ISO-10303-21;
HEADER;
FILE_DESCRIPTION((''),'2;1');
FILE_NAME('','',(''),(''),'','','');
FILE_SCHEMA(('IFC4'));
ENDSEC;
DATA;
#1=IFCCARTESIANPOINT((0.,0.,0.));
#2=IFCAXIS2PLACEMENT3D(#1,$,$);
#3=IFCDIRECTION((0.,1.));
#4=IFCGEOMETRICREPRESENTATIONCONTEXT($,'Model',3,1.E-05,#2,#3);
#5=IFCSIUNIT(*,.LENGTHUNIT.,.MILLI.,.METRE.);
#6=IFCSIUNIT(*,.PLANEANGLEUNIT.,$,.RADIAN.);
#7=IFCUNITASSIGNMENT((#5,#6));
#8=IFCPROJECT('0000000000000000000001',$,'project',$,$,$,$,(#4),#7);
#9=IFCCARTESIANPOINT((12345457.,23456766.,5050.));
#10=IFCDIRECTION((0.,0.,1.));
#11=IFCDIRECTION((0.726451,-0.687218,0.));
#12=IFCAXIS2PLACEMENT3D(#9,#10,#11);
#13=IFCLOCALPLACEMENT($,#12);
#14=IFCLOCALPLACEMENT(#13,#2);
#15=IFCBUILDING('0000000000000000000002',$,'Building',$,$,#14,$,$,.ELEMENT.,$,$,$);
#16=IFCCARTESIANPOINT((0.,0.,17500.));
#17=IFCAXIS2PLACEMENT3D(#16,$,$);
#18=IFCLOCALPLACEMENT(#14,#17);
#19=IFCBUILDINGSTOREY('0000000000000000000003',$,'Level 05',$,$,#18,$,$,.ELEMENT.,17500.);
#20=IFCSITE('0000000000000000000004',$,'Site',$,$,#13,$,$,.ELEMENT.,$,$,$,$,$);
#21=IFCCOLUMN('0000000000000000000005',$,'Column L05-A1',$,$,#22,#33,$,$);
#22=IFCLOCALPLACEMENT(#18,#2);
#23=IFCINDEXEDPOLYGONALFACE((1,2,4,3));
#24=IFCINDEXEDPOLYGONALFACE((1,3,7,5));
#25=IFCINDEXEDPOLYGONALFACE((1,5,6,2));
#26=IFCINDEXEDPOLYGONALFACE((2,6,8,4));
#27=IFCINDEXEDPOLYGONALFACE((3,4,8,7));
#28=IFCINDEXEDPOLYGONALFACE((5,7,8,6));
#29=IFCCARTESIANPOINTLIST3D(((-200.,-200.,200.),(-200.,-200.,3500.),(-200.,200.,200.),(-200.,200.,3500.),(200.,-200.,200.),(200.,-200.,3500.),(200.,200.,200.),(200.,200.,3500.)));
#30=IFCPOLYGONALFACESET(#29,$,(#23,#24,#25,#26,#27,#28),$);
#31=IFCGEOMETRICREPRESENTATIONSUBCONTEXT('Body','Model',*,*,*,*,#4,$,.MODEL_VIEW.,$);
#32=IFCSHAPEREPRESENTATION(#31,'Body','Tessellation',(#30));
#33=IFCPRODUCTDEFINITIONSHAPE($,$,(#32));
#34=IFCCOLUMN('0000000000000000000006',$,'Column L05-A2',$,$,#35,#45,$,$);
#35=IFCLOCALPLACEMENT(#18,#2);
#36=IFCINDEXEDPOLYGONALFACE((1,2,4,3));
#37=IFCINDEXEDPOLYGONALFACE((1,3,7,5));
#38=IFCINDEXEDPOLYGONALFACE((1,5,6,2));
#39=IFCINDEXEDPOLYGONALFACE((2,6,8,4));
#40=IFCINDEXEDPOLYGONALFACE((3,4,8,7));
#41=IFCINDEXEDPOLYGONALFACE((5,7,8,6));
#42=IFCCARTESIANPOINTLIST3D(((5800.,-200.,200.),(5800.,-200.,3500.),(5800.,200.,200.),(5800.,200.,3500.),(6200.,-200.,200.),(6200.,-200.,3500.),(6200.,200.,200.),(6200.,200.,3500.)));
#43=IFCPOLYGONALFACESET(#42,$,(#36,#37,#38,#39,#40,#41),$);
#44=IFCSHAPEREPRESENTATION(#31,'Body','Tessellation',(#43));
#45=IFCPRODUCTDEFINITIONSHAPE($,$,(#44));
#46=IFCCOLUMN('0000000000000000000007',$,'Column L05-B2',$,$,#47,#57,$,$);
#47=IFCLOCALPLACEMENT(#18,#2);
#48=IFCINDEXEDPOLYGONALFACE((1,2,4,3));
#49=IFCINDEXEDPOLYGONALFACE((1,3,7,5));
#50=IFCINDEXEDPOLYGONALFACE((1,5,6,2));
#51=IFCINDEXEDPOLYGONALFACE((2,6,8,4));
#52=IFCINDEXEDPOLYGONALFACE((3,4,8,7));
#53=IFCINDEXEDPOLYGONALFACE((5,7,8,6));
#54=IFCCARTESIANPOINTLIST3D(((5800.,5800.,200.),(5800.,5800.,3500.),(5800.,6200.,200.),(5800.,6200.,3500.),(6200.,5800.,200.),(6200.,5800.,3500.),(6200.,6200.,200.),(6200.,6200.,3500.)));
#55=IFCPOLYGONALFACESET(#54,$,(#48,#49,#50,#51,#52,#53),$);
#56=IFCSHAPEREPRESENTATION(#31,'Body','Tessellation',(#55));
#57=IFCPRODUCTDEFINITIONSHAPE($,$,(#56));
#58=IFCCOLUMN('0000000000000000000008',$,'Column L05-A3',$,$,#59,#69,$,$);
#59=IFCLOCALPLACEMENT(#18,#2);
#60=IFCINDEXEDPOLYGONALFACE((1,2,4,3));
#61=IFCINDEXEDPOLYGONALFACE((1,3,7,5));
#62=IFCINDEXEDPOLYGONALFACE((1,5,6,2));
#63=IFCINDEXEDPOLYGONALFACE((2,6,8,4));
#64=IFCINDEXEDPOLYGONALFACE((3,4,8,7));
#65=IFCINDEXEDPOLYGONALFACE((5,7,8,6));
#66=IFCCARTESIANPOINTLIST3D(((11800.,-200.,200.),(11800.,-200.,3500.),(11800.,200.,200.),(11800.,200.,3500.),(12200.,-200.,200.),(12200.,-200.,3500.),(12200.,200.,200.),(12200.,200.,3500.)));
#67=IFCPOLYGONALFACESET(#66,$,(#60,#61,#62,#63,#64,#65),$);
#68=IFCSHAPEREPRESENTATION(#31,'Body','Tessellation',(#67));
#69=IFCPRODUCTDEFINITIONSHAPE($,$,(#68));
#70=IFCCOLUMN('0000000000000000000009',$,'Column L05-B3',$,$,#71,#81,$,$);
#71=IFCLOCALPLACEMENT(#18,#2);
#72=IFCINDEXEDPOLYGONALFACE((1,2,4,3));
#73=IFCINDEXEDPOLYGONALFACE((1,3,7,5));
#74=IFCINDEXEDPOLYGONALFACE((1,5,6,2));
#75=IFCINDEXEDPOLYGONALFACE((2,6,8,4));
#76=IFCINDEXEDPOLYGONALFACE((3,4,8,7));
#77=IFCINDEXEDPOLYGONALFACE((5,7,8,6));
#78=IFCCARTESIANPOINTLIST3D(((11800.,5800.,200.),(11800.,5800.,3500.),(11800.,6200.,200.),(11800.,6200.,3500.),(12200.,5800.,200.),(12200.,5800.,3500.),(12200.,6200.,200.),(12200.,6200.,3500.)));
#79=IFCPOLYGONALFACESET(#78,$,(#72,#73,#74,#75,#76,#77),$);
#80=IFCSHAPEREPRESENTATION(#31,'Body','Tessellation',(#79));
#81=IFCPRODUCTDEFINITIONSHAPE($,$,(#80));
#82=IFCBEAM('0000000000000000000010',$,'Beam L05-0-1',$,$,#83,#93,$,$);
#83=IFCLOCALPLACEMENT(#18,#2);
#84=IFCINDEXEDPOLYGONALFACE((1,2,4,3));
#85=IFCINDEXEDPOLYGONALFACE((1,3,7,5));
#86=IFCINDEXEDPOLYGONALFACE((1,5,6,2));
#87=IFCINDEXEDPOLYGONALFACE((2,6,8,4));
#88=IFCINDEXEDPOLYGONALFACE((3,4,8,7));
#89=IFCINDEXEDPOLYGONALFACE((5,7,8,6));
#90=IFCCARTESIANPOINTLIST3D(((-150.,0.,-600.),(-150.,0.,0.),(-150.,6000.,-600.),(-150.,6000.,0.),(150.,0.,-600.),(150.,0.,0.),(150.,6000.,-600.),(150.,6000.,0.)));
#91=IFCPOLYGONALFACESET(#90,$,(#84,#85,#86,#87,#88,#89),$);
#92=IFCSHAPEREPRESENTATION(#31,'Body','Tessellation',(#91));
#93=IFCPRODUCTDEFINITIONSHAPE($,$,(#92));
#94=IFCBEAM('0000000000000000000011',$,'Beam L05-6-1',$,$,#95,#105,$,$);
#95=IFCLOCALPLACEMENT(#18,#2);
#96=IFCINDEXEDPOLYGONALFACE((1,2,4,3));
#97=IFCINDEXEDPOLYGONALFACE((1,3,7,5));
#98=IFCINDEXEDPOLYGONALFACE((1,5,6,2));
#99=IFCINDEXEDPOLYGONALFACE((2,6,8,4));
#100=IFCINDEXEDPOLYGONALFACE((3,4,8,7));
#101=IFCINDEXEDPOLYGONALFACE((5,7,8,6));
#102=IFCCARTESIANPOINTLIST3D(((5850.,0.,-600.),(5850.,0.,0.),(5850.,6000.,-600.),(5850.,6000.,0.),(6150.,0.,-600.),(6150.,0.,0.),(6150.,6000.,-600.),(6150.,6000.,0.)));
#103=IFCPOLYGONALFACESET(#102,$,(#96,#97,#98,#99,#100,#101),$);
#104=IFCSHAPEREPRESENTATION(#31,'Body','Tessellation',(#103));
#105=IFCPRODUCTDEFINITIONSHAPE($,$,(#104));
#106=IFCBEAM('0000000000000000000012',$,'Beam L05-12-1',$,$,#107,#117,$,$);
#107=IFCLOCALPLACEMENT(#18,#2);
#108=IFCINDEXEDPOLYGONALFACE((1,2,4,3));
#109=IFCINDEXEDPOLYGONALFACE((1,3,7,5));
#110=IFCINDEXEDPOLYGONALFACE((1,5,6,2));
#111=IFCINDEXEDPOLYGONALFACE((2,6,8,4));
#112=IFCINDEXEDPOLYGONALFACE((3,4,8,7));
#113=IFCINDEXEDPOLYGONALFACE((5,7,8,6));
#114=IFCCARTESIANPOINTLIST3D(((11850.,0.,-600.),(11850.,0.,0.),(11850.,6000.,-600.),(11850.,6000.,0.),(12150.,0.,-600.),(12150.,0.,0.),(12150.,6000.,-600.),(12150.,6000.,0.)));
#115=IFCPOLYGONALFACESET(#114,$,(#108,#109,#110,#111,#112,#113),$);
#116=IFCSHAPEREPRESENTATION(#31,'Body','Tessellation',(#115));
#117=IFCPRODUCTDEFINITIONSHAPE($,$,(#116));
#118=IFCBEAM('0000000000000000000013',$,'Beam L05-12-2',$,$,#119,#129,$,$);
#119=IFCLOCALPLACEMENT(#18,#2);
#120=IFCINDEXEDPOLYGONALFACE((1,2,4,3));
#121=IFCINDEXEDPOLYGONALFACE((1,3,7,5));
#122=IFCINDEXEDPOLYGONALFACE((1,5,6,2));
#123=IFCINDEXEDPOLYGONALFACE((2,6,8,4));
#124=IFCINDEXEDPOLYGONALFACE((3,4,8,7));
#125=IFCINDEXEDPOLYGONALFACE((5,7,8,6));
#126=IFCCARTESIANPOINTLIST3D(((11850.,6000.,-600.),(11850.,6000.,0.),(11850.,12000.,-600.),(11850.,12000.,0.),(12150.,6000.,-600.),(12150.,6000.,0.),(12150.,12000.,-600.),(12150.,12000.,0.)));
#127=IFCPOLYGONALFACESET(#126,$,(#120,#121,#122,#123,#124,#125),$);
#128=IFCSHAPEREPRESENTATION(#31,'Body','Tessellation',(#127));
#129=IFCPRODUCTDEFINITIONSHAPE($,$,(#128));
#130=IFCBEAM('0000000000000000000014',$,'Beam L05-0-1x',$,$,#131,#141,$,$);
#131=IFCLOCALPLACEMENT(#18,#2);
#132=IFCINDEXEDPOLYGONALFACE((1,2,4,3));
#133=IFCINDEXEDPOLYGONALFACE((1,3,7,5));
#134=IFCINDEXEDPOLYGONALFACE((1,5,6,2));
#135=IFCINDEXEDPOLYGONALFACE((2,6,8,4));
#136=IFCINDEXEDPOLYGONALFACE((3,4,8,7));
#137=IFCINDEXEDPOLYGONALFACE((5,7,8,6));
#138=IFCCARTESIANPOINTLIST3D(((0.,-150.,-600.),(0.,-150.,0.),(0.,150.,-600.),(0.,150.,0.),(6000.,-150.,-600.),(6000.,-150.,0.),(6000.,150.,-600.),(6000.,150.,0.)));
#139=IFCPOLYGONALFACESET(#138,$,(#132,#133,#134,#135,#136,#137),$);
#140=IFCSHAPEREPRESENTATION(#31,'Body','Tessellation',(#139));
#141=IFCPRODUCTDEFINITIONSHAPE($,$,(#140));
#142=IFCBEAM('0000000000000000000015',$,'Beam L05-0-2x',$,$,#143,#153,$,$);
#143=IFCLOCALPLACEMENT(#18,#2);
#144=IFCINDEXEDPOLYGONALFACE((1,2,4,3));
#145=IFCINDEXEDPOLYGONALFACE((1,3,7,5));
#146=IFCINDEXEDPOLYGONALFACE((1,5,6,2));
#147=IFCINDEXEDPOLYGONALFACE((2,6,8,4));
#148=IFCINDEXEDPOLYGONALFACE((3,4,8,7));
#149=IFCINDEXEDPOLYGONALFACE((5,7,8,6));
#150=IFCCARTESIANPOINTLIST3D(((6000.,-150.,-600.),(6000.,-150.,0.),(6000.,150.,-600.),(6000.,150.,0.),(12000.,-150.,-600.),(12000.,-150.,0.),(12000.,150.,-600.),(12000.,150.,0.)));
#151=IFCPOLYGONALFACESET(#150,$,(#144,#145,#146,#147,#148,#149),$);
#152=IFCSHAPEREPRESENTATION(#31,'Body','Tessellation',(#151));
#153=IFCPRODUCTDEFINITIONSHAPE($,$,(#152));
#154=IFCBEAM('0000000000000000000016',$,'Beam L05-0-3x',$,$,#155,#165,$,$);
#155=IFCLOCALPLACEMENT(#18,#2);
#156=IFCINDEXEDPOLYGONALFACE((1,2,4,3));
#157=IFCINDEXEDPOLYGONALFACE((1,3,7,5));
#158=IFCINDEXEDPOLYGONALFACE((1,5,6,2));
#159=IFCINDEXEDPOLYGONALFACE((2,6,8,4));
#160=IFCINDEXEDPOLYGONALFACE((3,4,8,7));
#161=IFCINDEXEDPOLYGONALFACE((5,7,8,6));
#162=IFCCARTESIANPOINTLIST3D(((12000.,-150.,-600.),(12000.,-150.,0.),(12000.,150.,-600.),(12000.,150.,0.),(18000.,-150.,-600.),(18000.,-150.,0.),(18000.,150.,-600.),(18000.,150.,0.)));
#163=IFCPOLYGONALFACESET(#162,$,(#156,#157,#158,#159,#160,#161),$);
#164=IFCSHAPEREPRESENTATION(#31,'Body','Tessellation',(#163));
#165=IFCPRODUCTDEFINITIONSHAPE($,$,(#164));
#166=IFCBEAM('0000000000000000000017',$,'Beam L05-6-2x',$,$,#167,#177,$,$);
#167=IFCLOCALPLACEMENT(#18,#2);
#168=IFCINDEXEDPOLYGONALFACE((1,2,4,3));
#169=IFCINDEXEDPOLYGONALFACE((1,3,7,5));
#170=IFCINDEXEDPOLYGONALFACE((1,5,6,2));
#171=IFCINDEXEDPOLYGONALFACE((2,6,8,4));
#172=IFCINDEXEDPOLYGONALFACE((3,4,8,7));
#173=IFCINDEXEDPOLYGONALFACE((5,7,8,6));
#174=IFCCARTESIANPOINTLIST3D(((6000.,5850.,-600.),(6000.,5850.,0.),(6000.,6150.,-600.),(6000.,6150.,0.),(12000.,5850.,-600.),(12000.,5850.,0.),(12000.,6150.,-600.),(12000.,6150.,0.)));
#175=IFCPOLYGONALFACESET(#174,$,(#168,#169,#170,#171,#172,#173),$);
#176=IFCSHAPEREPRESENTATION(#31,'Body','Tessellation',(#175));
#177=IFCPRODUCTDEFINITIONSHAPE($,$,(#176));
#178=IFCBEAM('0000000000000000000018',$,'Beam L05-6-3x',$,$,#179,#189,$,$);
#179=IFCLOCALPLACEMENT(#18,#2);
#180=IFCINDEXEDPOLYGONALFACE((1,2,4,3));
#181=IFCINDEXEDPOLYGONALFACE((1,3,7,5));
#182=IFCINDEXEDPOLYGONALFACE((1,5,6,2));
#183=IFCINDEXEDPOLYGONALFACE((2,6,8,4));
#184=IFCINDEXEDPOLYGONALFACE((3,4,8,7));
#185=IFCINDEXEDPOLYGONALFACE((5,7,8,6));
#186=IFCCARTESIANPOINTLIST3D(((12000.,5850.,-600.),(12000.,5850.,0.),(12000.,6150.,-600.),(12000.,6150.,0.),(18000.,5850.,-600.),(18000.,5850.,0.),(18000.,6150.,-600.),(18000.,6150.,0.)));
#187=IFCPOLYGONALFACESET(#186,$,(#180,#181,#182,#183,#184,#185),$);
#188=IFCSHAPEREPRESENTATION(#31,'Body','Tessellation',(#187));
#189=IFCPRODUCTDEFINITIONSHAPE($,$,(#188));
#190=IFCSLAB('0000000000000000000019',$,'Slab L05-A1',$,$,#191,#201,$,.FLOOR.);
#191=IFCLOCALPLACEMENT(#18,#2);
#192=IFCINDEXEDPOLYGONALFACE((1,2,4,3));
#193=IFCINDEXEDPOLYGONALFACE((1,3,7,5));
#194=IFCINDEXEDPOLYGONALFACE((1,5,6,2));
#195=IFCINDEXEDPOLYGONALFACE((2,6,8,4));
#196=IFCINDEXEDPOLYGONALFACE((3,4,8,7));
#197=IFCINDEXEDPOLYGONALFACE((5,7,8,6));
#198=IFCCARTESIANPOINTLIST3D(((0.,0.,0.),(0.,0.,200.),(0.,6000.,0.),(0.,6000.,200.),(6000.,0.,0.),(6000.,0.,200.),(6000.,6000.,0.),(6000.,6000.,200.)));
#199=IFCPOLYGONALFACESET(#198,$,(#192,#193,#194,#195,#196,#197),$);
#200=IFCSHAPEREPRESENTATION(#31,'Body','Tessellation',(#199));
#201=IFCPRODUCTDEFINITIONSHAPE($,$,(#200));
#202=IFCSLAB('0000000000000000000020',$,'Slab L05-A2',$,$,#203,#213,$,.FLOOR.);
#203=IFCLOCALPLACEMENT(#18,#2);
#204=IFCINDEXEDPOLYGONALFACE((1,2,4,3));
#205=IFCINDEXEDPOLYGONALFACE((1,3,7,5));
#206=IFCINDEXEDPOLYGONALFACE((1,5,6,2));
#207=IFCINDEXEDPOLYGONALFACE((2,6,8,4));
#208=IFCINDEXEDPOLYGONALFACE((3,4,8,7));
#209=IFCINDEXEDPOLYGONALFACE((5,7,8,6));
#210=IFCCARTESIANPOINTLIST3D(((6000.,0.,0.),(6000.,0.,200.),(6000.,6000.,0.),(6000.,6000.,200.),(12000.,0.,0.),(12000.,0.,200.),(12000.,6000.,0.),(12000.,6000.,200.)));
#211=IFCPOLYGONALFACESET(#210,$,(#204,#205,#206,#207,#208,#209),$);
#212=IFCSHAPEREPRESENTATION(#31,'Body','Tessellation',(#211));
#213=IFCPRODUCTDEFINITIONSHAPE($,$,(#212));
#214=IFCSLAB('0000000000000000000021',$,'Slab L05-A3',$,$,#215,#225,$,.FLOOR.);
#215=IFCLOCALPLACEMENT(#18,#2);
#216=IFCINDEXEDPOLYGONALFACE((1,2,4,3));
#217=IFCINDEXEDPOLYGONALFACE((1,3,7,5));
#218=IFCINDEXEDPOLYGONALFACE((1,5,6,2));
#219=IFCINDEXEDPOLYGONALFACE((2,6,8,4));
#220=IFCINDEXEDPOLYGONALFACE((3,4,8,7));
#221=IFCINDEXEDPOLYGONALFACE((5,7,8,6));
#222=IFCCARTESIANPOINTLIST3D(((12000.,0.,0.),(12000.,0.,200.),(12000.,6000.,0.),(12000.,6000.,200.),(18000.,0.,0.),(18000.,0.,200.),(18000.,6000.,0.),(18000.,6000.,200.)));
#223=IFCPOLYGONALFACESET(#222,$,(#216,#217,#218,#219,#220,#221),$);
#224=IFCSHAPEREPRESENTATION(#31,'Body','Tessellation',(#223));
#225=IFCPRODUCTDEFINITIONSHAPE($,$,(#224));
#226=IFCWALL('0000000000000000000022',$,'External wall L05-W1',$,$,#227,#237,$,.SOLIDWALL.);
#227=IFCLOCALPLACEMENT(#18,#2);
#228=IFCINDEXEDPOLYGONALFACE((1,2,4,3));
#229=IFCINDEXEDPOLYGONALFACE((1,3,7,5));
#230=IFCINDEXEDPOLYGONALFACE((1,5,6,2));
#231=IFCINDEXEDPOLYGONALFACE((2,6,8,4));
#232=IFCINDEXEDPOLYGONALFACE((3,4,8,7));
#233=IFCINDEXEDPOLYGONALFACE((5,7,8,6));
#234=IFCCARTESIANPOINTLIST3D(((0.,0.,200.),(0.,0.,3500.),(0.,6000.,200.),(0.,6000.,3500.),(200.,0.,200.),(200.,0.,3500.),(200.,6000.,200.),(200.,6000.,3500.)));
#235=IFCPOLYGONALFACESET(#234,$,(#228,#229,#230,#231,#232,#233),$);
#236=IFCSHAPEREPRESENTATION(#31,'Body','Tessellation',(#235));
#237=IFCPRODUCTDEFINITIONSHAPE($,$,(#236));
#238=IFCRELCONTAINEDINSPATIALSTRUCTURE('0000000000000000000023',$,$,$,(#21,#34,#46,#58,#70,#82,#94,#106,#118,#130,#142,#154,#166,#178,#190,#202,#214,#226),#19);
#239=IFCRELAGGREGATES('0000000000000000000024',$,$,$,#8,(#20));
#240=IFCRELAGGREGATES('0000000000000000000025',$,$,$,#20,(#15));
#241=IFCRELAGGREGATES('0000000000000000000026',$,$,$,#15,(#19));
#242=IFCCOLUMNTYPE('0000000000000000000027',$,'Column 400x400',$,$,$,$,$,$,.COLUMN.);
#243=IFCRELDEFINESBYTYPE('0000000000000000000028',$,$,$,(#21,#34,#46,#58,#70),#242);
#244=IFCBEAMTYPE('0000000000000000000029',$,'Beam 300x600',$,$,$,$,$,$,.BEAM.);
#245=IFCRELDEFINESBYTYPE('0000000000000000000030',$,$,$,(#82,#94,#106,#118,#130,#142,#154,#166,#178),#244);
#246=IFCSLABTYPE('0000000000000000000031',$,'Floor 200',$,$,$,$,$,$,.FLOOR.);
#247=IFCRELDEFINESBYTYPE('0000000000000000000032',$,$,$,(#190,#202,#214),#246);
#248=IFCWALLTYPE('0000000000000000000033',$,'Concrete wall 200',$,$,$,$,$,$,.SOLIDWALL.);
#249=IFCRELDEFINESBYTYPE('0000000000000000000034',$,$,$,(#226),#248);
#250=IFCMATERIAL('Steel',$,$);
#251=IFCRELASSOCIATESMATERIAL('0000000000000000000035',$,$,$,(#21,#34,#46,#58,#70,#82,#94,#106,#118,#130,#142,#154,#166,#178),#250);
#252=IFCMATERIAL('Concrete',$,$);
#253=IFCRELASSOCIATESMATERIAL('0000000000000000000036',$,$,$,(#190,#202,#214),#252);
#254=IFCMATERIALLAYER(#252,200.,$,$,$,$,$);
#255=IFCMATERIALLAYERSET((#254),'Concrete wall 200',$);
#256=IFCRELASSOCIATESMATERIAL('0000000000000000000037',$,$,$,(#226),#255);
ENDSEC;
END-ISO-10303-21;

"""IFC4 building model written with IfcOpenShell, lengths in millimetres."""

from ifc_helpers import new_model, si_unit, direction, frame, origin, place, context, subcontext, project, spatial, rectangle, extrude, material, layer, layer_set, layer_usage, type_object, element, save


model = new_model("IFC4")

# Units and contexts
model_context = context("Model", 3, precision=1e-05, world=origin(), true_north=direction((0.0, 1.0)))
body_context = subcontext(model_context, "Body", "Model", "MODEL_VIEW")
ifc_project = project(units=[si_unit("LENGTHUNIT", "METRE", prefix="MILLI"), si_unit("PLANEANGLEUNIT", "RADIAN")], contexts=[model_context])

# Site, building, storey
site_placement = place(None, frame((12345457.0, 23456766.0, 5050.0), z_axis=(0.0, 0.0, 1.0), x_axis=(0.726451, -0.687218, 0.0)))
site = spatial("IfcSite", under=ifc_project, at=site_placement, Name="Site", CompositionType="ELEMENT")
building_placement = place(site_placement, origin())
building = spatial("IfcBuilding", under=site, at=building_placement, Name="Building", CompositionType="ELEMENT")
storey_placement = place(building_placement, frame((0.0, 0.0, 17500.0)))
storey = spatial("IfcBuildingStorey", under=building, at=storey_placement, Name="Level 05", CompositionType="ELEMENT", Elevation=17500.0)

# Columns
ifc_material_1 = material(Name="Steel")
column_type = type_object("IfcColumnType", Name="Column 400x400", PredefinedType="COLUMN")
for number, where, name in (
    (1, (-200.0, -200.0, 200.0), "Column L05-A1"),
    (2, (5800.0, -200.0, 200.0), "Column L05-A2"),
    (3, (5800.0, 5800.0, 200.0), "Column L05-B2"),
    (4, (11800.0, -200.0, 200.0), "Column L05-A3"),
    (5, (11800.0, 5800.0, 200.0), "Column L05-B3"),
):
    element("IfcColumn", number, at=place(storey_placement, frame(where)), inside=storey, type_object=column_type, material=ifc_material_1, Name=name, context=body_context, shape_type="SweptSolid", body=[
        extrude(rectangle(XDim=400.0, YDim=400.0), frame((200.0, 200.0, 0.0)), (0.0, 0.0, 1.0), 3300.0),
    ])

# Beams
beam_type = type_object("IfcBeamType", Name="Beam 300x600", PredefinedType="BEAM")
for number, where, name in (
    (6, (-150.0, 0.0, -600.0), "Beam L05-0-1"),
    (7, (5850.0, 0.0, -600.0), "Beam L05-6-1"),
    (8, (11850.0, 0.0, -600.0), "Beam L05-12-1"),
    (9, (11850.0, 6000.0, -600.0), "Beam L05-12-2"),
):
    element("IfcBeam", number, at=place(storey_placement, frame(where)), inside=storey, type_object=beam_type, material=ifc_material_1, Name=name, context=body_context, shape_type="SweptSolid", body=[
        extrude(rectangle(XDim=300.0, YDim=6000.0), frame((150.0, 3000.0, 0.0)), (0.0, 0.0, 1.0), 600.0),
    ])
for number, where, name in (
    (10, (0.0, -150.0, -600.0), "Beam L05-0-1x"),
    (11, (6000.0, -150.0, -600.0), "Beam L05-0-2x"),
    (12, (12000.0, -150.0, -600.0), "Beam L05-0-3x"),
    (13, (6000.0, 5850.0, -600.0), "Beam L05-6-2x"),
    (14, (12000.0, 5850.0, -600.0), "Beam L05-6-3x"),
):
    element("IfcBeam", number, at=place(storey_placement, frame(where)), inside=storey, type_object=beam_type, material=ifc_material_1, Name=name, context=body_context, shape_type="SweptSolid", body=[
        extrude(rectangle(XDim=6000.0, YDim=300.0), frame((3000.0, 150.0, 0.0)), (0.0, 0.0, 1.0), 600.0),
    ])

# Slabs
ifc_material_2 = material(Name="Concrete")
slab_type = type_object("IfcSlabType", Name="Floor 200", PredefinedType="FLOOR")
for number, where, name in (
    (15, (0.0, 0.0, 0.0), "Slab L05-A1"),
    (16, (6000.0, 0.0, 0.0), "Slab L05-A2"),
    (17, (12000.0, 0.0, 0.0), "Slab L05-A3"),
):
    element("IfcSlab", number, at=place(storey_placement, frame(where)), inside=storey, type_object=slab_type, material=ifc_material_2, Name=name, PredefinedType="FLOOR", context=body_context, shape_type="SweptSolid", body=[
        extrude(rectangle(XDim=6000.0, YDim=6000.0), frame((3000.0, 3000.0, 0.0)), (0.0, 0.0, 1.0), 200.0),
    ])

# Wall
ifc_layer_1 = layer(ifc_material_2, 200.0)
ifc_layer_set_1 = layer_set([ifc_layer_1], Name="Concrete wall 200")
ifc_layer_usage_1 = layer_usage(ifc_layer_set_1, "AXIS2", "POSITIVE", 0.0)
wall_type_1 = type_object("IfcWallType", Name="Concrete wall 200", PredefinedType="SOLIDWALL")
wall_placement = place(storey_placement, frame((0.0, 0.0, 200.0)))
element("IfcWall", 18, at=wall_placement, inside=storey, type_object=wall_type_1, material=ifc_layer_usage_1, Name="External wall L05-W1", PredefinedType="SOLIDWALL", context=body_context, shape_type="SweptSolid", body=[
    extrude(rectangle(XDim=200.0, YDim=6000.0), frame((100.0, 3000.0, 0.0)), (0.0, 0.0, 1.0), 3300.0),
])

save(model, "model.ifc")
